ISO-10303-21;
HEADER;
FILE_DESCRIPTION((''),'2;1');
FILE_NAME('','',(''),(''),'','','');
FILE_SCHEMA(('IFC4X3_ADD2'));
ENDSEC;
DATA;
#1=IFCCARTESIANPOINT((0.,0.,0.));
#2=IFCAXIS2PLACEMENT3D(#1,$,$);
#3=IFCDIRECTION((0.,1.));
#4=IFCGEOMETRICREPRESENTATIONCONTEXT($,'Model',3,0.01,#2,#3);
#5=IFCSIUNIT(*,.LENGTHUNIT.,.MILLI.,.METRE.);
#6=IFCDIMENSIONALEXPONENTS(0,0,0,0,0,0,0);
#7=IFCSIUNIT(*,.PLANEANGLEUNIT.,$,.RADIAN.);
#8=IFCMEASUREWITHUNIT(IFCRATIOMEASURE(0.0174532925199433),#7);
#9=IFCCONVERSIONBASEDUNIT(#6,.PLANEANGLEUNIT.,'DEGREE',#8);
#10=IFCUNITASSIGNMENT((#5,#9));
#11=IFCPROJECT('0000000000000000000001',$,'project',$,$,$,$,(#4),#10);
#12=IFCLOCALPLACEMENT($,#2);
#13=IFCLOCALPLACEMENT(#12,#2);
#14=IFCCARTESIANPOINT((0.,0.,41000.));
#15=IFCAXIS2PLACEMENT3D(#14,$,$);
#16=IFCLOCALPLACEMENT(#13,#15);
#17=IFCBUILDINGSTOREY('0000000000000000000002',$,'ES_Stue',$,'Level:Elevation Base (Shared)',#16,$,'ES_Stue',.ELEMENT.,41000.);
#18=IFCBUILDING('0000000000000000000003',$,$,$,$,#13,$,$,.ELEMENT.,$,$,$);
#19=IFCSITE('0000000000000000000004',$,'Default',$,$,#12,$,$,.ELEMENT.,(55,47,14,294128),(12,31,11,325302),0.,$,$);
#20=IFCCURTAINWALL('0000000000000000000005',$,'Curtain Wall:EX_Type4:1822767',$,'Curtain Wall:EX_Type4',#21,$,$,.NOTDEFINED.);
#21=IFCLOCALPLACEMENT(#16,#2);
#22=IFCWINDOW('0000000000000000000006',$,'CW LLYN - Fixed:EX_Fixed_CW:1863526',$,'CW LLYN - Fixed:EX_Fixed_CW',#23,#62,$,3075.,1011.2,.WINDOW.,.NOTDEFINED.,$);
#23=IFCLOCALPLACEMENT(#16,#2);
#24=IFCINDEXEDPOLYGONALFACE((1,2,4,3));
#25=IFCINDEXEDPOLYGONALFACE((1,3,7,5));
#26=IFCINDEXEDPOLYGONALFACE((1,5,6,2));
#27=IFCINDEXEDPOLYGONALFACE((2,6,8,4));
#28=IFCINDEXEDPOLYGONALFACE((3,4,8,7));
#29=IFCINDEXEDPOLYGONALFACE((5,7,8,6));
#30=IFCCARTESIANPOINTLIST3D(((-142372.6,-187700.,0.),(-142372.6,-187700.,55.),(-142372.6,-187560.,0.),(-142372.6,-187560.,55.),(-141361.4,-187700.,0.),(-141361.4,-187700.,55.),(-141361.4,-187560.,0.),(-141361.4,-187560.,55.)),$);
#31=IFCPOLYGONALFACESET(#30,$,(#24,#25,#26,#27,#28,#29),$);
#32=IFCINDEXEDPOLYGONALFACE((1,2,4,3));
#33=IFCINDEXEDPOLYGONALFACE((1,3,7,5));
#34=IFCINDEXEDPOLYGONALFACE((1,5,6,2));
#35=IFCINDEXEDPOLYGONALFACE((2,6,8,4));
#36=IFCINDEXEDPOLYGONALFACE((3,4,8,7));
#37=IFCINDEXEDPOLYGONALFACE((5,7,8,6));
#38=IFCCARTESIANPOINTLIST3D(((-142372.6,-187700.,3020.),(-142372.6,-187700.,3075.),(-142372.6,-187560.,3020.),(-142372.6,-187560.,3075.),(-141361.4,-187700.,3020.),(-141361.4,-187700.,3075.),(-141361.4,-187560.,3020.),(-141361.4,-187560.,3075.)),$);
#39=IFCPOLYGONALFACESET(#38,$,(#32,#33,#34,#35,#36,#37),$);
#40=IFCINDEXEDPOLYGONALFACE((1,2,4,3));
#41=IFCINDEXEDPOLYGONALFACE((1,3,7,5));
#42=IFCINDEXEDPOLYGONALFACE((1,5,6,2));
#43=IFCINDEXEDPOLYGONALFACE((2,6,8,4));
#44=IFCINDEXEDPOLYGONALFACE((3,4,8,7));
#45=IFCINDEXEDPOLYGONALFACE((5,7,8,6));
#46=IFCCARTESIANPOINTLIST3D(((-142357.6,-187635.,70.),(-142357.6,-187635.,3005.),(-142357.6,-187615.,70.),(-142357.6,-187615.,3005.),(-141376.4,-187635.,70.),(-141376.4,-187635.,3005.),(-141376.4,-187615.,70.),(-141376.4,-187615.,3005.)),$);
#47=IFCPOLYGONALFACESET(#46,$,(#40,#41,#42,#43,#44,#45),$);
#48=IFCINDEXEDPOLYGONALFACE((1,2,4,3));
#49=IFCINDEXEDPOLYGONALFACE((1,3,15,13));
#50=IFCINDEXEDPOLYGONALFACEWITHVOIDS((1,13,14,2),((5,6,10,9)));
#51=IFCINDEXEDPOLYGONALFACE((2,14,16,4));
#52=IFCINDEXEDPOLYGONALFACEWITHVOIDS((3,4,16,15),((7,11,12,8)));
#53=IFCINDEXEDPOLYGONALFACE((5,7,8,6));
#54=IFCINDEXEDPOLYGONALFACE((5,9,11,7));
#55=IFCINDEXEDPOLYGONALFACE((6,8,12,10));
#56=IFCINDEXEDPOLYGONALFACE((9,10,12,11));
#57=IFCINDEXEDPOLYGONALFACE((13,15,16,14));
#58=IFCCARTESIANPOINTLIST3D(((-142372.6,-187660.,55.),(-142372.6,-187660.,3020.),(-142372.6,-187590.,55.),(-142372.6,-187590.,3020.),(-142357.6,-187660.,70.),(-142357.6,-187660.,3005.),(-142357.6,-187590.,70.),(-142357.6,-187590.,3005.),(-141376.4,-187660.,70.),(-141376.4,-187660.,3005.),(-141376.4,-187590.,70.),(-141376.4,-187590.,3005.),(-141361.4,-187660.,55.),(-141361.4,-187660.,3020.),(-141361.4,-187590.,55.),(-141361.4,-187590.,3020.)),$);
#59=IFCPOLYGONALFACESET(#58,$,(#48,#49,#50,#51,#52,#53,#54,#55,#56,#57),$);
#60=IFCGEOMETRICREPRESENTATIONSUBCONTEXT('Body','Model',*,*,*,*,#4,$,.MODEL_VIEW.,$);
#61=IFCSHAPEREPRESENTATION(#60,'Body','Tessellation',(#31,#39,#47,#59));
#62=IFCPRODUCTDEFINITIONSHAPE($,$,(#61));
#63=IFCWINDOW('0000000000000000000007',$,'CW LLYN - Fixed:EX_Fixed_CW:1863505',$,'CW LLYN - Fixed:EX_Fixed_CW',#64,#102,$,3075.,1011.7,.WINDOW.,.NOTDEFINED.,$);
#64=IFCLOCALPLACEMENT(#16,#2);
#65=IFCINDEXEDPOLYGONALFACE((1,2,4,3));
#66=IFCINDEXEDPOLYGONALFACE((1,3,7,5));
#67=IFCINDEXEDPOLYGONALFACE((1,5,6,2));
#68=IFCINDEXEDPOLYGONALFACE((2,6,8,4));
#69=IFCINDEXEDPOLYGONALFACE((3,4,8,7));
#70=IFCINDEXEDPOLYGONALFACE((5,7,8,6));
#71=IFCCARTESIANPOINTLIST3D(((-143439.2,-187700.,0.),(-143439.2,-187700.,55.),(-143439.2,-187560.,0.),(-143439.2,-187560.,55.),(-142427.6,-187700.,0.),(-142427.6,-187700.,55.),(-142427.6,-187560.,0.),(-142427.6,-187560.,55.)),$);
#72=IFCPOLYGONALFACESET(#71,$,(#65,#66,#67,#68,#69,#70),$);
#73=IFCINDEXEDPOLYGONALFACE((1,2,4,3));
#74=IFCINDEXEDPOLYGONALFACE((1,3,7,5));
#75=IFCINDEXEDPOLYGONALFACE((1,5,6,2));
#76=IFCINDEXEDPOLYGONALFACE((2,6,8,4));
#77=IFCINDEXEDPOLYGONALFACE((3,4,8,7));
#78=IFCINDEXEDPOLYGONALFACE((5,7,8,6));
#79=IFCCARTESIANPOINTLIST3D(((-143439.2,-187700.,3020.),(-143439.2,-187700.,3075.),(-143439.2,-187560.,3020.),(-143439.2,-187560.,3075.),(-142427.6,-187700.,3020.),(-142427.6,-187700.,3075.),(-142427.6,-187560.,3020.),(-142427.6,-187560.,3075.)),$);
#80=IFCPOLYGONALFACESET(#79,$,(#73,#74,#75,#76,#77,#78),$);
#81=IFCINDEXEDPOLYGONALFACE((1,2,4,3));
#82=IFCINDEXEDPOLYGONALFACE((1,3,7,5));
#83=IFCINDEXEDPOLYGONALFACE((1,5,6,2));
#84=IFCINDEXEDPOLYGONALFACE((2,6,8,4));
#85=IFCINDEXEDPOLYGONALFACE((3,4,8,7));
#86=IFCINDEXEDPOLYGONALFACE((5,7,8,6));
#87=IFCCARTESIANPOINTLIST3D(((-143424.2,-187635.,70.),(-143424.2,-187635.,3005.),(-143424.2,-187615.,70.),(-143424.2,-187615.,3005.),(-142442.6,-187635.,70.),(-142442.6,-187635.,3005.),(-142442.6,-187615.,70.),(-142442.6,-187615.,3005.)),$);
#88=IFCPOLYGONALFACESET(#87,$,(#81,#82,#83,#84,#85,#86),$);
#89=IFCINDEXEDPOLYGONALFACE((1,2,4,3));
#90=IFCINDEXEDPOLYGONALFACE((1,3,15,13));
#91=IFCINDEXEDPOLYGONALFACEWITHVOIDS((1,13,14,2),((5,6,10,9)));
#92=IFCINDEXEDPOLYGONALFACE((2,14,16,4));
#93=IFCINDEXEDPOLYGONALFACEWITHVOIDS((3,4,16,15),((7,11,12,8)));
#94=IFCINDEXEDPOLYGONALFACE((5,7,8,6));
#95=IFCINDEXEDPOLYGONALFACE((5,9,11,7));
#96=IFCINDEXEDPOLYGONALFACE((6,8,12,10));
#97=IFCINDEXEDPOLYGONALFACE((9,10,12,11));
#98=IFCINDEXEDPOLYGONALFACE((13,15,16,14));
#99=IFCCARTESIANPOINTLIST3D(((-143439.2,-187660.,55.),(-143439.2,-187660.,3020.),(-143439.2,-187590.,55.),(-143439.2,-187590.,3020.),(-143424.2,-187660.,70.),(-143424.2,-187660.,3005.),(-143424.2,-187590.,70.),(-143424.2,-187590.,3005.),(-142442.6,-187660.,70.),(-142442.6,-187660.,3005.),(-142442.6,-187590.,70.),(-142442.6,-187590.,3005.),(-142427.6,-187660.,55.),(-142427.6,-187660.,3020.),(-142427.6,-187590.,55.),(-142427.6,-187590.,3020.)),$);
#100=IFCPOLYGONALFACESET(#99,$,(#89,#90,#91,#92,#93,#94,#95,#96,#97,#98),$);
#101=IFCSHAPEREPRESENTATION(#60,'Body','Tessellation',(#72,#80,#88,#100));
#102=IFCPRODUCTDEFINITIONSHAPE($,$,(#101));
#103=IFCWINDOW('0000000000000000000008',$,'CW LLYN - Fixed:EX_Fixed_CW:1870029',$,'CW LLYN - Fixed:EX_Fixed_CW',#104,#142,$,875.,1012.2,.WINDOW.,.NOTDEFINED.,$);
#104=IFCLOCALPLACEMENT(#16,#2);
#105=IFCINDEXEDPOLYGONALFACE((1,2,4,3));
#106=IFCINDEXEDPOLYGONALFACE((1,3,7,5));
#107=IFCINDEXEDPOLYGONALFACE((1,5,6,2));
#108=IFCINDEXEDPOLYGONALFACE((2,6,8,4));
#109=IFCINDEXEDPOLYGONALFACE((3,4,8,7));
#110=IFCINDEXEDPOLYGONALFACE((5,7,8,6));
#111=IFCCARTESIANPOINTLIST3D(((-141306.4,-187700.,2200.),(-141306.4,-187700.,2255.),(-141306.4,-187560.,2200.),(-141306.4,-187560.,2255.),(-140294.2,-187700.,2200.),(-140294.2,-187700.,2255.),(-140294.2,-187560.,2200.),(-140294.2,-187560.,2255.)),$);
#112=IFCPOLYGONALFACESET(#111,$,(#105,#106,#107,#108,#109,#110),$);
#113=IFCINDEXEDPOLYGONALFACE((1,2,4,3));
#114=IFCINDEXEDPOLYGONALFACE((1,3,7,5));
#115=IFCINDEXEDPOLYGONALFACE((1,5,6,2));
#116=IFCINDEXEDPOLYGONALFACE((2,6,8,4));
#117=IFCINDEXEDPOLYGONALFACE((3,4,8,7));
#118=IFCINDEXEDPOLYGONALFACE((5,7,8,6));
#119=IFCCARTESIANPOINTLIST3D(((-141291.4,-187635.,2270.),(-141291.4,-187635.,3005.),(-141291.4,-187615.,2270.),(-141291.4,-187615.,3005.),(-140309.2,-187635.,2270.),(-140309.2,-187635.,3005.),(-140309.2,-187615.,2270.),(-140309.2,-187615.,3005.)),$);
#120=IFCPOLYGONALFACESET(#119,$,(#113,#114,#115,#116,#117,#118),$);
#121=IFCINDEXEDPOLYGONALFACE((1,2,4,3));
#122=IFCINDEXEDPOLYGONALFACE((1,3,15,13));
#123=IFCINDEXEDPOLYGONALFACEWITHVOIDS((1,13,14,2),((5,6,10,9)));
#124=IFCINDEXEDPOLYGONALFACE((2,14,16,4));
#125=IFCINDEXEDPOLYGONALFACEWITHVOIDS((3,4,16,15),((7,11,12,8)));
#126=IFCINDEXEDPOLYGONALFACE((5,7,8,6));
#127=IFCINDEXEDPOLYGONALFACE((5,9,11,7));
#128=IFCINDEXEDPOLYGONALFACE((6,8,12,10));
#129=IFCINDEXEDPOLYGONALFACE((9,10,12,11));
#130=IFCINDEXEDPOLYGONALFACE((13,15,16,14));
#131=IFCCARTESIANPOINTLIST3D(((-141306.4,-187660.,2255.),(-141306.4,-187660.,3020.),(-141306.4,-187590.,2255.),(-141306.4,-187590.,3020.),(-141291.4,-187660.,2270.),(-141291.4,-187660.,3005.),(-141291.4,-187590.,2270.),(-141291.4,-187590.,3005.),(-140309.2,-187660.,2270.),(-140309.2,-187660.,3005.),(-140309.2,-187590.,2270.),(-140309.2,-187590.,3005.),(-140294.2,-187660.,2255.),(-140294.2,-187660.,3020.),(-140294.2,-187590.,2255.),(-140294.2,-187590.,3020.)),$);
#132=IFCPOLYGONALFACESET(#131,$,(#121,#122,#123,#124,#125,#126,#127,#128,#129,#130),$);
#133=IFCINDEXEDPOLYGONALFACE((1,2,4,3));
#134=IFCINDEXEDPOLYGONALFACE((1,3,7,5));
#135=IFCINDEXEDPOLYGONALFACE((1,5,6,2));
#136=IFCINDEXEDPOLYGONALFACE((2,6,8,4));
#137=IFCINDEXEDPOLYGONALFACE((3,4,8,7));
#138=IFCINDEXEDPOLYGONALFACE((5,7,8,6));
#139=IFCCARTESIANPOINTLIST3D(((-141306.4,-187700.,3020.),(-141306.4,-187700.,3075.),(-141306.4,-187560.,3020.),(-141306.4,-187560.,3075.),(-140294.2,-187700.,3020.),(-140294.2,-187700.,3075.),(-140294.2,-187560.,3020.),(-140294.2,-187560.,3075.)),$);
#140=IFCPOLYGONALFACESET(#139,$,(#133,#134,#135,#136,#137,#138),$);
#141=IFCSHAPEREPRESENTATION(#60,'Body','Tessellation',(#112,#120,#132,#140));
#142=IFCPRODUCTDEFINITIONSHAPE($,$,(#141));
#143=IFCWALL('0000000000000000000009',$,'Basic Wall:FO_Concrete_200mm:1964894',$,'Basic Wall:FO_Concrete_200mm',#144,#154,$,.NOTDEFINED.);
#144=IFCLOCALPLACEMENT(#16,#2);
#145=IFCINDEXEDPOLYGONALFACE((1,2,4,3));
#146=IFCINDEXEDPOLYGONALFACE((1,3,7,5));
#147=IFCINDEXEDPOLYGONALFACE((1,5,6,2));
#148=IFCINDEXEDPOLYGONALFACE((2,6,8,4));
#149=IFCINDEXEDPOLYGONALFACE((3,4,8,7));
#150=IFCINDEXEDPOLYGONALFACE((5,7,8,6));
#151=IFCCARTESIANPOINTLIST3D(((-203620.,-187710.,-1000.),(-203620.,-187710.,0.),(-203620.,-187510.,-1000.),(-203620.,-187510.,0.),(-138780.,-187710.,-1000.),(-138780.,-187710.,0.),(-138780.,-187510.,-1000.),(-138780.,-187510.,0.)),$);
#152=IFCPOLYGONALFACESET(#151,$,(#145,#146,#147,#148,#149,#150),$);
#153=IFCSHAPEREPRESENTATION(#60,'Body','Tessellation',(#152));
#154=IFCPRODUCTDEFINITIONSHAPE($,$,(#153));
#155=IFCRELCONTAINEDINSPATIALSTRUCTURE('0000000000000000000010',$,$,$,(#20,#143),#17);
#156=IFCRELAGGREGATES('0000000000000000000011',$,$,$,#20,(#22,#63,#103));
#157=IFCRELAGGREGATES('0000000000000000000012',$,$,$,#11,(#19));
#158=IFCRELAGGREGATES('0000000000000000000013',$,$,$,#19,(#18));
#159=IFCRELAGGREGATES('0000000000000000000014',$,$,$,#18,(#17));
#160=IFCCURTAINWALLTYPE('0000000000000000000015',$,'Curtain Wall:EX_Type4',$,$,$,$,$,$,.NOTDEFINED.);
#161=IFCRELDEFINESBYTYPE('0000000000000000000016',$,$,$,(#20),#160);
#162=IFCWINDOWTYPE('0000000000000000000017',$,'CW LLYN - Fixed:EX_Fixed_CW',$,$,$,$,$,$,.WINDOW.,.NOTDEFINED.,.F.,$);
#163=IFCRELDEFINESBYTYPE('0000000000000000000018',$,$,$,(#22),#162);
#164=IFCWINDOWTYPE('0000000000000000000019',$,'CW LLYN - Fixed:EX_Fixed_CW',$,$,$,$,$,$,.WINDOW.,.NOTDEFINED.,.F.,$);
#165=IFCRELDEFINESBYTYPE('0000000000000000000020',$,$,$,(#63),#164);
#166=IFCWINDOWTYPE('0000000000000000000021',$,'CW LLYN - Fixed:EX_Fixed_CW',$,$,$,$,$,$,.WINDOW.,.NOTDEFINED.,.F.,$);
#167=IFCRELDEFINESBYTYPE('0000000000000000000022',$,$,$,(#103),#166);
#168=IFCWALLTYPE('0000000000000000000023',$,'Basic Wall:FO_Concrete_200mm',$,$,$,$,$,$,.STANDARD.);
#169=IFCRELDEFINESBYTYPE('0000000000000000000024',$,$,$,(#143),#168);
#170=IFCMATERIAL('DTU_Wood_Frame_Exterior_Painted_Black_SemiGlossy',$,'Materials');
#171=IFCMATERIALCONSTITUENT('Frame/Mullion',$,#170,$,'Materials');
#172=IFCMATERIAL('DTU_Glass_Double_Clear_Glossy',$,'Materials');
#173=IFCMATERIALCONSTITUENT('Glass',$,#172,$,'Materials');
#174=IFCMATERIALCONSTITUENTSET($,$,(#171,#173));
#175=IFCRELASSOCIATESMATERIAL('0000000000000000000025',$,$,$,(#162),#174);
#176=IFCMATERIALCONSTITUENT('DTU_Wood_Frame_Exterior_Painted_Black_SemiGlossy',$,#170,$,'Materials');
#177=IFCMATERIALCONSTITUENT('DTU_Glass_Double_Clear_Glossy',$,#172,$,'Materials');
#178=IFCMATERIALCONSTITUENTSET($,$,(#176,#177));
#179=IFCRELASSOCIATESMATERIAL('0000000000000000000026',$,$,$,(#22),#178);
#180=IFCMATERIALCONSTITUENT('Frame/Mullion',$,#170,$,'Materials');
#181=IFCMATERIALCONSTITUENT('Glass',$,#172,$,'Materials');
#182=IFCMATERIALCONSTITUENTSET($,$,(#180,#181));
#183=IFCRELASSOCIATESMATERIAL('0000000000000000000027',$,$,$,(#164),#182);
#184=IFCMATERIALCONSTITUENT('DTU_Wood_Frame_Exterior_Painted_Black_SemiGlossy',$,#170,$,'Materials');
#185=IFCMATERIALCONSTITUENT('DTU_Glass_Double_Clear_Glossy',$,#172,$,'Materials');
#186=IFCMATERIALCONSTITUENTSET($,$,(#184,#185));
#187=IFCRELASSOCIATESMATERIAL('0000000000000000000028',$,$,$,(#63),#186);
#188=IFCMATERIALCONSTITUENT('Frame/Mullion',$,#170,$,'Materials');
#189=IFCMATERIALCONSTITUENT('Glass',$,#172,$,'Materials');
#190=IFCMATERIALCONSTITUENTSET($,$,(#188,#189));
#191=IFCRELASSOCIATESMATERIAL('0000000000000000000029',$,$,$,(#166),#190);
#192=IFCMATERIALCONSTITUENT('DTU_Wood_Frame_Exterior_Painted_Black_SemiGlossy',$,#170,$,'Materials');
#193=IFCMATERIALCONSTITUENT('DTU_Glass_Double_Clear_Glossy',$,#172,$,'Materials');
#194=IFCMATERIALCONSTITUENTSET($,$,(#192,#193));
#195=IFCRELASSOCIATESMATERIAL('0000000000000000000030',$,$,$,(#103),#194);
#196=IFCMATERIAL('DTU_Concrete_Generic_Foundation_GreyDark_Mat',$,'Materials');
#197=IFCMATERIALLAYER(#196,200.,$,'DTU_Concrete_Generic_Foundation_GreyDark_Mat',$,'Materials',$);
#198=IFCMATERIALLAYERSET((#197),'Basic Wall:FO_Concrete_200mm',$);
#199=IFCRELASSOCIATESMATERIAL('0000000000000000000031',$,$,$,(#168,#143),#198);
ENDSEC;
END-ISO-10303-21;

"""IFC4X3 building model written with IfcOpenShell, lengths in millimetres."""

from ifc_helpers import new_model, entity, si_unit, converted_unit, direction, frame, frame_2d, origin, origin_2d_with_axis, place, context, subcontext, project, spatial, polyline, rectangle, outline, extrude, source, transform, mapped, material, layer, layer_set, constituent, constituent_set, type_object, type_shapes, element, aggregate, save


model = new_model("IFC4X3")

# Units and contexts
model_context = context("Model", 3, precision=0.01, world=origin(), true_north=direction((0.0, 1.0)))
body_context = subcontext(model_context, "Body", "Model", "MODEL_VIEW")
ifc_project = project(units=[si_unit("LENGTHUNIT", "METRE", prefix="MILLI"), converted_unit("PLANEANGLEUNIT", "DEGREE", entity("IfcRatioMeasure", 0.0174532925199433), si_unit("PLANEANGLEUNIT", "RADIAN"), dimensions=[0, 0, 0, 0, 0, 0, 0])], contexts=[model_context])

# Site, building, storey
site_placement = place(None, origin())
site = spatial("IfcSite", under=ifc_project, at=site_placement, Name="Default", CompositionType="ELEMENT", RefLatitude=(55, 47, 14, 294128), RefLongitude=(12, 31, 11, 325302), RefElevation=0.0)
building_placement = place(site_placement, origin())
building = spatial("IfcBuilding", under=site, at=building_placement, CompositionType="ELEMENT")
storey_placement = place(building_placement, frame((0.0, 0.0, 41000.0)))
storey = spatial("IfcBuildingStorey", under=building, at=storey_placement, Name="ES_Stue", ObjectType="Level:Elevation Base (Shared)", LongName="ES_Stue", CompositionType="ELEMENT", Elevation=41000.0)

# Curtain wall, windows
curtain_wall_type_1 = type_object("IfcCurtainWallType", Name="Curtain Wall:EX_Type4", PredefinedType="NOTDEFINED")
curtain_wall_1_placement = place(storey_placement, frame((0.0, 0.0, -41000.0)))
curtain_wall_1 = element("IfcCurtainWall", 1, at=curtain_wall_1_placement, inside=storey, type_object=curtain_wall_type_1, Name="Curtain Wall:EX_Type4:1822767", ObjectType="Curtain Wall:EX_Type4", PredefinedType="NOTDEFINED")
ifc_material_1 = material(Name="DTU_Wood_Frame_Exterior_Painted_Black_SemiGlossy", Category="Materials")
ifc_material_2 = material(Name="DTU_Glass_Double_Clear_Glossy", Category="Materials")
ifc_constituent_1 = constituent(ifc_material_1, Name="DTU_Wood_Frame_Exterior_Painted_Black_SemiGlossy", Category="Materials")
ifc_constituent_2 = constituent(ifc_material_2, Name="DTU_Glass_Double_Clear_Glossy", Category="Materials")
ifc_constituent_set_1 = constituent_set(constituents=[ifc_constituent_1, ifc_constituent_2])
ifc_constituent_3 = constituent(ifc_material_1, Name="Frame/Mullion", Category="Materials")
ifc_constituent_4 = constituent(ifc_material_2, Name="Glass", Category="Materials")
ifc_constituent_set_2 = constituent_set(constituents=[ifc_constituent_3, ifc_constituent_4])
window_type_1 = type_object("IfcWindowType", Name="CW LLYN - Fixed:EX_Fixed_CW", ParameterTakesPrecedence=False, PartitioningType="NOTDEFINED", PredefinedType="WINDOW", material=ifc_constituent_set_2)
shared_shape_1 = source(origin(), body_context, "Body", "SweptSolid", [
    extrude(rectangle(XDim=140.0, YDim=1011.2, at=origin_2d_with_axis()), frame((0.0, -130.0, 0.0), z_axis=(0.0, 0.0, 1.0), x_axis=(0.0, -1.0, 0.0)), (0.0, 0.0, 1.0), 55.0),
    extrude(rectangle(XDim=140.0, YDim=1011.2, at=frame_2d((0.0, 0.0), x_axis=(1.0, 0.0))), frame((0.0, -130.0, 3020.0), z_axis=(0.0, 0.0, 1.0), x_axis=(0.0, -1.0, 0.0)), (0.0, 0.0, 1.0), 55.0),
    extrude(rectangle(XDim=981.2, YDim=20.0, at=origin_2d_with_axis()), frame((0.0, -125.0, 70.0), z_axis=(0.0, 0.0, 1.0), x_axis=(-1.0, 0.0, 0.0)), (0.0, 0.0, 1.0), 2935.0),
    extrude(outline(polyline([(-1482.5, -505.6), (1482.5, -505.6), (1482.5, 505.6), (-1482.5, 505.6), (-1482.5, -505.6)]), holes=[polyline([(-1467.5, 490.6), (1467.5, 490.6), (1467.5, -490.6), (-1467.5, -490.6), (-1467.5, 490.6)])]), frame((0.0, -90.0, 1537.5), z_axis=(0.0, -1.0, 0.0), x_axis=(0.0, 0.0, 1.0)), (0.0, 0.0, 1.0), 70.0),
])
type_shapes(window_type_1, [shared_shape_1])
window_1_placement = place(curtain_wall_1_placement, frame((-141867.0, -187500.0, 41000.0)))
window_1 = element("IfcWindow", 2, at=window_1_placement, type_object=window_type_1, material=ifc_constituent_set_1, Name="CW LLYN - Fixed:EX_Fixed_CW:1863526", ObjectType="CW LLYN - Fixed:EX_Fixed_CW", OverallHeight=3075.0, OverallWidth=1011.2, PartitioningType="NOTDEFINED", PredefinedType="WINDOW", context=body_context, shape_type="MappedRepresentation", body=[
    mapped(shared_shape_1, transform((0.0, 0.0, 0.0), scale=1.0)),
])
ifc_constituent_5 = constituent(ifc_material_1, Name="DTU_Wood_Frame_Exterior_Painted_Black_SemiGlossy", Category="Materials")
ifc_constituent_6 = constituent(ifc_material_2, Name="DTU_Glass_Double_Clear_Glossy", Category="Materials")
ifc_constituent_set_3 = constituent_set(constituents=[ifc_constituent_5, ifc_constituent_6])
ifc_constituent_7 = constituent(ifc_material_1, Name="Frame/Mullion", Category="Materials")
ifc_constituent_8 = constituent(ifc_material_2, Name="Glass", Category="Materials")
ifc_constituent_set_4 = constituent_set(constituents=[ifc_constituent_7, ifc_constituent_8])
window_type_2 = type_object("IfcWindowType", Name="CW LLYN - Fixed:EX_Fixed_CW", ParameterTakesPrecedence=False, PartitioningType="NOTDEFINED", PredefinedType="WINDOW", material=ifc_constituent_set_4)
shared_shape_2 = source(origin(), body_context, "Body", "SweptSolid", [
    extrude(rectangle(XDim=140.0, YDim=1011.7, at=origin_2d_with_axis()), frame((0.0, -130.0, 0.0), z_axis=(0.0, 0.0, 1.0), x_axis=(0.0, -1.0, 0.0)), (0.0, 0.0, 1.0), 55.0),
    extrude(rectangle(XDim=140.0, YDim=1011.7, at=frame_2d((0.0, 0.0), x_axis=(1.0, 0.0))), frame((0.0, -130.0, 3020.0), z_axis=(0.0, 0.0, 1.0), x_axis=(0.0, -1.0, 0.0)), (0.0, 0.0, 1.0), 55.0),
    extrude(rectangle(XDim=981.7, YDim=20.0, at=frame_2d((0.0, 0.0), x_axis=(1.0, 0.0))), frame((0.0, -125.0, 70.0), z_axis=(0.0, 0.0, 1.0), x_axis=(-1.0, 0.0, 0.0)), (0.0, 0.0, 1.0), 2935.0),
    extrude(outline(polyline([(-1482.5, -505.8), (1482.5, -505.8), (1482.5, 505.8), (-1482.5, 505.8), (-1482.5, -505.8)]), holes=[polyline([(-1467.5, 490.8), (1467.5, 490.8), (1467.5, -490.8), (-1467.5, -490.8), (-1467.5, 490.8)])]), frame((0.0, -90.0, 1537.5), z_axis=(0.0, -1.0, 0.0), x_axis=(0.0, 0.0, 1.0)), (0.0, 0.0, 1.0), 70.0),
])
type_shapes(window_type_2, [shared_shape_2])
window_2_placement = place(curtain_wall_1_placement, frame((-142933.4, -187500.0, 41000.0)))
window_2 = element("IfcWindow", 3, at=window_2_placement, type_object=window_type_2, material=ifc_constituent_set_3, Name="CW LLYN - Fixed:EX_Fixed_CW:1863505", ObjectType="CW LLYN - Fixed:EX_Fixed_CW", OverallHeight=3075.0, OverallWidth=1011.7, PartitioningType="NOTDEFINED", PredefinedType="WINDOW", context=body_context, shape_type="MappedRepresentation", body=[
    mapped(shared_shape_2, transform((0.0, 0.0, 0.0), scale=1.0)),
])
ifc_constituent_9 = constituent(ifc_material_1, Name="DTU_Wood_Frame_Exterior_Painted_Black_SemiGlossy", Category="Materials")
ifc_constituent_10 = constituent(ifc_material_2, Name="DTU_Glass_Double_Clear_Glossy", Category="Materials")
ifc_constituent_set_5 = constituent_set(constituents=[ifc_constituent_9, ifc_constituent_10])
ifc_constituent_11 = constituent(ifc_material_1, Name="Frame/Mullion", Category="Materials")
ifc_constituent_12 = constituent(ifc_material_2, Name="Glass", Category="Materials")
ifc_constituent_set_6 = constituent_set(constituents=[ifc_constituent_11, ifc_constituent_12])
window_type_3 = type_object("IfcWindowType", Name="CW LLYN - Fixed:EX_Fixed_CW", ParameterTakesPrecedence=False, PartitioningType="NOTDEFINED", PredefinedType="WINDOW", material=ifc_constituent_set_6)
shared_shape_3 = source(origin(), body_context, "Body", "SweptSolid", [
    extrude(rectangle(XDim=140.0, YDim=1012.2, at=origin_2d_with_axis()), frame((0.0, -130.0, 0.0), z_axis=(0.0, 0.0, 1.0), x_axis=(0.0, -1.0, 0.0)), (0.0, 0.0, 1.0), 55.0),
    extrude(rectangle(XDim=982.2, YDim=20.0, at=frame_2d((0.0, 0.0), x_axis=(1.0, 0.0))), frame((0.0, -125.0, 70.0), z_axis=(0.0, 0.0, 1.0), x_axis=(-1.0, 0.0, 0.0)), (0.0, 0.0, 1.0), 735.0),
    extrude(outline(polyline([(-382.5, -506.1), (382.5, -506.1), (382.5, 506.1), (-382.5, 506.1), (-382.5, -506.1)]), holes=[polyline([(-367.5, 491.1), (367.5, 491.1), (367.5, -491.1), (-367.5, -491.1), (-367.5, 491.1)])]), frame((0.0, -90.0, 437.5), z_axis=(0.0, -1.0, 0.0), x_axis=(0.0, 0.0, 1.0)), (0.0, 0.0, 1.0), 70.0),
    extrude(rectangle(XDim=140.0, YDim=1012.2, at=frame_2d((0.0, 0.0), x_axis=(1.0, 0.0))), frame((0.0, -130.0, 820.0), z_axis=(0.0, 0.0, 1.0), x_axis=(0.0, -1.0, 0.0)), (0.0, 0.0, 1.0), 55.0),
])
type_shapes(window_type_3, [shared_shape_3])
window_3_placement = place(curtain_wall_1_placement, frame((-140800.3, -187500.0, 43200.0)))
window_3 = element("IfcWindow", 4, at=window_3_placement, type_object=window_type_3, material=ifc_constituent_set_5, Name="CW LLYN - Fixed:EX_Fixed_CW:1870029", ObjectType="CW LLYN - Fixed:EX_Fixed_CW", OverallHeight=875.0, OverallWidth=1012.2, PartitioningType="NOTDEFINED", PredefinedType="WINDOW", context=body_context, shape_type="MappedRepresentation", body=[
    mapped(shared_shape_3, transform((0.0, 0.0, 0.0), scale=1.0)),
])
aggregate(curtain_wall_1, [window_1, window_2, window_3])

# Wall
ifc_material_3 = material(Name="DTU_Concrete_Generic_Foundation_GreyDark_Mat", Category="Materials")
ifc_layer_1 = layer(ifc_material_3, 200.0, Name="DTU_Concrete_Generic_Foundation_GreyDark_Mat", Category="Materials")
ifc_layer_set_1 = layer_set([ifc_layer_1], Name="Basic Wall:FO_Concrete_200mm")
wall_type = type_object("IfcWallType", Name="Basic Wall:FO_Concrete_200mm", PredefinedType="STANDARD", material=ifc_layer_set_1)
wall_placement = place(storey_placement, frame((-138780.0, -187610.0, -1000.0), z_axis=(0.0, 0.0, 1.0), x_axis=(-1.0, 0.0, 0.0)))
element("IfcWall", 5, at=wall_placement, inside=storey, type_object=wall_type, material=ifc_layer_set_1, Name="Basic Wall:FO_Concrete_200mm:1964894", ObjectType="Basic Wall:FO_Concrete_200mm", PredefinedType="NOTDEFINED", context=body_context, shape_type="SweptSolid", body=[
    extrude(rectangle(XDim=64840.0, YDim=200.0, at=frame_2d((32420.0, 0.0), x_axis=(-1.0, 0.0))), origin(), (0.0, 0.0, 1.0), 1000.0),
])

save(model, "model.ifc")
